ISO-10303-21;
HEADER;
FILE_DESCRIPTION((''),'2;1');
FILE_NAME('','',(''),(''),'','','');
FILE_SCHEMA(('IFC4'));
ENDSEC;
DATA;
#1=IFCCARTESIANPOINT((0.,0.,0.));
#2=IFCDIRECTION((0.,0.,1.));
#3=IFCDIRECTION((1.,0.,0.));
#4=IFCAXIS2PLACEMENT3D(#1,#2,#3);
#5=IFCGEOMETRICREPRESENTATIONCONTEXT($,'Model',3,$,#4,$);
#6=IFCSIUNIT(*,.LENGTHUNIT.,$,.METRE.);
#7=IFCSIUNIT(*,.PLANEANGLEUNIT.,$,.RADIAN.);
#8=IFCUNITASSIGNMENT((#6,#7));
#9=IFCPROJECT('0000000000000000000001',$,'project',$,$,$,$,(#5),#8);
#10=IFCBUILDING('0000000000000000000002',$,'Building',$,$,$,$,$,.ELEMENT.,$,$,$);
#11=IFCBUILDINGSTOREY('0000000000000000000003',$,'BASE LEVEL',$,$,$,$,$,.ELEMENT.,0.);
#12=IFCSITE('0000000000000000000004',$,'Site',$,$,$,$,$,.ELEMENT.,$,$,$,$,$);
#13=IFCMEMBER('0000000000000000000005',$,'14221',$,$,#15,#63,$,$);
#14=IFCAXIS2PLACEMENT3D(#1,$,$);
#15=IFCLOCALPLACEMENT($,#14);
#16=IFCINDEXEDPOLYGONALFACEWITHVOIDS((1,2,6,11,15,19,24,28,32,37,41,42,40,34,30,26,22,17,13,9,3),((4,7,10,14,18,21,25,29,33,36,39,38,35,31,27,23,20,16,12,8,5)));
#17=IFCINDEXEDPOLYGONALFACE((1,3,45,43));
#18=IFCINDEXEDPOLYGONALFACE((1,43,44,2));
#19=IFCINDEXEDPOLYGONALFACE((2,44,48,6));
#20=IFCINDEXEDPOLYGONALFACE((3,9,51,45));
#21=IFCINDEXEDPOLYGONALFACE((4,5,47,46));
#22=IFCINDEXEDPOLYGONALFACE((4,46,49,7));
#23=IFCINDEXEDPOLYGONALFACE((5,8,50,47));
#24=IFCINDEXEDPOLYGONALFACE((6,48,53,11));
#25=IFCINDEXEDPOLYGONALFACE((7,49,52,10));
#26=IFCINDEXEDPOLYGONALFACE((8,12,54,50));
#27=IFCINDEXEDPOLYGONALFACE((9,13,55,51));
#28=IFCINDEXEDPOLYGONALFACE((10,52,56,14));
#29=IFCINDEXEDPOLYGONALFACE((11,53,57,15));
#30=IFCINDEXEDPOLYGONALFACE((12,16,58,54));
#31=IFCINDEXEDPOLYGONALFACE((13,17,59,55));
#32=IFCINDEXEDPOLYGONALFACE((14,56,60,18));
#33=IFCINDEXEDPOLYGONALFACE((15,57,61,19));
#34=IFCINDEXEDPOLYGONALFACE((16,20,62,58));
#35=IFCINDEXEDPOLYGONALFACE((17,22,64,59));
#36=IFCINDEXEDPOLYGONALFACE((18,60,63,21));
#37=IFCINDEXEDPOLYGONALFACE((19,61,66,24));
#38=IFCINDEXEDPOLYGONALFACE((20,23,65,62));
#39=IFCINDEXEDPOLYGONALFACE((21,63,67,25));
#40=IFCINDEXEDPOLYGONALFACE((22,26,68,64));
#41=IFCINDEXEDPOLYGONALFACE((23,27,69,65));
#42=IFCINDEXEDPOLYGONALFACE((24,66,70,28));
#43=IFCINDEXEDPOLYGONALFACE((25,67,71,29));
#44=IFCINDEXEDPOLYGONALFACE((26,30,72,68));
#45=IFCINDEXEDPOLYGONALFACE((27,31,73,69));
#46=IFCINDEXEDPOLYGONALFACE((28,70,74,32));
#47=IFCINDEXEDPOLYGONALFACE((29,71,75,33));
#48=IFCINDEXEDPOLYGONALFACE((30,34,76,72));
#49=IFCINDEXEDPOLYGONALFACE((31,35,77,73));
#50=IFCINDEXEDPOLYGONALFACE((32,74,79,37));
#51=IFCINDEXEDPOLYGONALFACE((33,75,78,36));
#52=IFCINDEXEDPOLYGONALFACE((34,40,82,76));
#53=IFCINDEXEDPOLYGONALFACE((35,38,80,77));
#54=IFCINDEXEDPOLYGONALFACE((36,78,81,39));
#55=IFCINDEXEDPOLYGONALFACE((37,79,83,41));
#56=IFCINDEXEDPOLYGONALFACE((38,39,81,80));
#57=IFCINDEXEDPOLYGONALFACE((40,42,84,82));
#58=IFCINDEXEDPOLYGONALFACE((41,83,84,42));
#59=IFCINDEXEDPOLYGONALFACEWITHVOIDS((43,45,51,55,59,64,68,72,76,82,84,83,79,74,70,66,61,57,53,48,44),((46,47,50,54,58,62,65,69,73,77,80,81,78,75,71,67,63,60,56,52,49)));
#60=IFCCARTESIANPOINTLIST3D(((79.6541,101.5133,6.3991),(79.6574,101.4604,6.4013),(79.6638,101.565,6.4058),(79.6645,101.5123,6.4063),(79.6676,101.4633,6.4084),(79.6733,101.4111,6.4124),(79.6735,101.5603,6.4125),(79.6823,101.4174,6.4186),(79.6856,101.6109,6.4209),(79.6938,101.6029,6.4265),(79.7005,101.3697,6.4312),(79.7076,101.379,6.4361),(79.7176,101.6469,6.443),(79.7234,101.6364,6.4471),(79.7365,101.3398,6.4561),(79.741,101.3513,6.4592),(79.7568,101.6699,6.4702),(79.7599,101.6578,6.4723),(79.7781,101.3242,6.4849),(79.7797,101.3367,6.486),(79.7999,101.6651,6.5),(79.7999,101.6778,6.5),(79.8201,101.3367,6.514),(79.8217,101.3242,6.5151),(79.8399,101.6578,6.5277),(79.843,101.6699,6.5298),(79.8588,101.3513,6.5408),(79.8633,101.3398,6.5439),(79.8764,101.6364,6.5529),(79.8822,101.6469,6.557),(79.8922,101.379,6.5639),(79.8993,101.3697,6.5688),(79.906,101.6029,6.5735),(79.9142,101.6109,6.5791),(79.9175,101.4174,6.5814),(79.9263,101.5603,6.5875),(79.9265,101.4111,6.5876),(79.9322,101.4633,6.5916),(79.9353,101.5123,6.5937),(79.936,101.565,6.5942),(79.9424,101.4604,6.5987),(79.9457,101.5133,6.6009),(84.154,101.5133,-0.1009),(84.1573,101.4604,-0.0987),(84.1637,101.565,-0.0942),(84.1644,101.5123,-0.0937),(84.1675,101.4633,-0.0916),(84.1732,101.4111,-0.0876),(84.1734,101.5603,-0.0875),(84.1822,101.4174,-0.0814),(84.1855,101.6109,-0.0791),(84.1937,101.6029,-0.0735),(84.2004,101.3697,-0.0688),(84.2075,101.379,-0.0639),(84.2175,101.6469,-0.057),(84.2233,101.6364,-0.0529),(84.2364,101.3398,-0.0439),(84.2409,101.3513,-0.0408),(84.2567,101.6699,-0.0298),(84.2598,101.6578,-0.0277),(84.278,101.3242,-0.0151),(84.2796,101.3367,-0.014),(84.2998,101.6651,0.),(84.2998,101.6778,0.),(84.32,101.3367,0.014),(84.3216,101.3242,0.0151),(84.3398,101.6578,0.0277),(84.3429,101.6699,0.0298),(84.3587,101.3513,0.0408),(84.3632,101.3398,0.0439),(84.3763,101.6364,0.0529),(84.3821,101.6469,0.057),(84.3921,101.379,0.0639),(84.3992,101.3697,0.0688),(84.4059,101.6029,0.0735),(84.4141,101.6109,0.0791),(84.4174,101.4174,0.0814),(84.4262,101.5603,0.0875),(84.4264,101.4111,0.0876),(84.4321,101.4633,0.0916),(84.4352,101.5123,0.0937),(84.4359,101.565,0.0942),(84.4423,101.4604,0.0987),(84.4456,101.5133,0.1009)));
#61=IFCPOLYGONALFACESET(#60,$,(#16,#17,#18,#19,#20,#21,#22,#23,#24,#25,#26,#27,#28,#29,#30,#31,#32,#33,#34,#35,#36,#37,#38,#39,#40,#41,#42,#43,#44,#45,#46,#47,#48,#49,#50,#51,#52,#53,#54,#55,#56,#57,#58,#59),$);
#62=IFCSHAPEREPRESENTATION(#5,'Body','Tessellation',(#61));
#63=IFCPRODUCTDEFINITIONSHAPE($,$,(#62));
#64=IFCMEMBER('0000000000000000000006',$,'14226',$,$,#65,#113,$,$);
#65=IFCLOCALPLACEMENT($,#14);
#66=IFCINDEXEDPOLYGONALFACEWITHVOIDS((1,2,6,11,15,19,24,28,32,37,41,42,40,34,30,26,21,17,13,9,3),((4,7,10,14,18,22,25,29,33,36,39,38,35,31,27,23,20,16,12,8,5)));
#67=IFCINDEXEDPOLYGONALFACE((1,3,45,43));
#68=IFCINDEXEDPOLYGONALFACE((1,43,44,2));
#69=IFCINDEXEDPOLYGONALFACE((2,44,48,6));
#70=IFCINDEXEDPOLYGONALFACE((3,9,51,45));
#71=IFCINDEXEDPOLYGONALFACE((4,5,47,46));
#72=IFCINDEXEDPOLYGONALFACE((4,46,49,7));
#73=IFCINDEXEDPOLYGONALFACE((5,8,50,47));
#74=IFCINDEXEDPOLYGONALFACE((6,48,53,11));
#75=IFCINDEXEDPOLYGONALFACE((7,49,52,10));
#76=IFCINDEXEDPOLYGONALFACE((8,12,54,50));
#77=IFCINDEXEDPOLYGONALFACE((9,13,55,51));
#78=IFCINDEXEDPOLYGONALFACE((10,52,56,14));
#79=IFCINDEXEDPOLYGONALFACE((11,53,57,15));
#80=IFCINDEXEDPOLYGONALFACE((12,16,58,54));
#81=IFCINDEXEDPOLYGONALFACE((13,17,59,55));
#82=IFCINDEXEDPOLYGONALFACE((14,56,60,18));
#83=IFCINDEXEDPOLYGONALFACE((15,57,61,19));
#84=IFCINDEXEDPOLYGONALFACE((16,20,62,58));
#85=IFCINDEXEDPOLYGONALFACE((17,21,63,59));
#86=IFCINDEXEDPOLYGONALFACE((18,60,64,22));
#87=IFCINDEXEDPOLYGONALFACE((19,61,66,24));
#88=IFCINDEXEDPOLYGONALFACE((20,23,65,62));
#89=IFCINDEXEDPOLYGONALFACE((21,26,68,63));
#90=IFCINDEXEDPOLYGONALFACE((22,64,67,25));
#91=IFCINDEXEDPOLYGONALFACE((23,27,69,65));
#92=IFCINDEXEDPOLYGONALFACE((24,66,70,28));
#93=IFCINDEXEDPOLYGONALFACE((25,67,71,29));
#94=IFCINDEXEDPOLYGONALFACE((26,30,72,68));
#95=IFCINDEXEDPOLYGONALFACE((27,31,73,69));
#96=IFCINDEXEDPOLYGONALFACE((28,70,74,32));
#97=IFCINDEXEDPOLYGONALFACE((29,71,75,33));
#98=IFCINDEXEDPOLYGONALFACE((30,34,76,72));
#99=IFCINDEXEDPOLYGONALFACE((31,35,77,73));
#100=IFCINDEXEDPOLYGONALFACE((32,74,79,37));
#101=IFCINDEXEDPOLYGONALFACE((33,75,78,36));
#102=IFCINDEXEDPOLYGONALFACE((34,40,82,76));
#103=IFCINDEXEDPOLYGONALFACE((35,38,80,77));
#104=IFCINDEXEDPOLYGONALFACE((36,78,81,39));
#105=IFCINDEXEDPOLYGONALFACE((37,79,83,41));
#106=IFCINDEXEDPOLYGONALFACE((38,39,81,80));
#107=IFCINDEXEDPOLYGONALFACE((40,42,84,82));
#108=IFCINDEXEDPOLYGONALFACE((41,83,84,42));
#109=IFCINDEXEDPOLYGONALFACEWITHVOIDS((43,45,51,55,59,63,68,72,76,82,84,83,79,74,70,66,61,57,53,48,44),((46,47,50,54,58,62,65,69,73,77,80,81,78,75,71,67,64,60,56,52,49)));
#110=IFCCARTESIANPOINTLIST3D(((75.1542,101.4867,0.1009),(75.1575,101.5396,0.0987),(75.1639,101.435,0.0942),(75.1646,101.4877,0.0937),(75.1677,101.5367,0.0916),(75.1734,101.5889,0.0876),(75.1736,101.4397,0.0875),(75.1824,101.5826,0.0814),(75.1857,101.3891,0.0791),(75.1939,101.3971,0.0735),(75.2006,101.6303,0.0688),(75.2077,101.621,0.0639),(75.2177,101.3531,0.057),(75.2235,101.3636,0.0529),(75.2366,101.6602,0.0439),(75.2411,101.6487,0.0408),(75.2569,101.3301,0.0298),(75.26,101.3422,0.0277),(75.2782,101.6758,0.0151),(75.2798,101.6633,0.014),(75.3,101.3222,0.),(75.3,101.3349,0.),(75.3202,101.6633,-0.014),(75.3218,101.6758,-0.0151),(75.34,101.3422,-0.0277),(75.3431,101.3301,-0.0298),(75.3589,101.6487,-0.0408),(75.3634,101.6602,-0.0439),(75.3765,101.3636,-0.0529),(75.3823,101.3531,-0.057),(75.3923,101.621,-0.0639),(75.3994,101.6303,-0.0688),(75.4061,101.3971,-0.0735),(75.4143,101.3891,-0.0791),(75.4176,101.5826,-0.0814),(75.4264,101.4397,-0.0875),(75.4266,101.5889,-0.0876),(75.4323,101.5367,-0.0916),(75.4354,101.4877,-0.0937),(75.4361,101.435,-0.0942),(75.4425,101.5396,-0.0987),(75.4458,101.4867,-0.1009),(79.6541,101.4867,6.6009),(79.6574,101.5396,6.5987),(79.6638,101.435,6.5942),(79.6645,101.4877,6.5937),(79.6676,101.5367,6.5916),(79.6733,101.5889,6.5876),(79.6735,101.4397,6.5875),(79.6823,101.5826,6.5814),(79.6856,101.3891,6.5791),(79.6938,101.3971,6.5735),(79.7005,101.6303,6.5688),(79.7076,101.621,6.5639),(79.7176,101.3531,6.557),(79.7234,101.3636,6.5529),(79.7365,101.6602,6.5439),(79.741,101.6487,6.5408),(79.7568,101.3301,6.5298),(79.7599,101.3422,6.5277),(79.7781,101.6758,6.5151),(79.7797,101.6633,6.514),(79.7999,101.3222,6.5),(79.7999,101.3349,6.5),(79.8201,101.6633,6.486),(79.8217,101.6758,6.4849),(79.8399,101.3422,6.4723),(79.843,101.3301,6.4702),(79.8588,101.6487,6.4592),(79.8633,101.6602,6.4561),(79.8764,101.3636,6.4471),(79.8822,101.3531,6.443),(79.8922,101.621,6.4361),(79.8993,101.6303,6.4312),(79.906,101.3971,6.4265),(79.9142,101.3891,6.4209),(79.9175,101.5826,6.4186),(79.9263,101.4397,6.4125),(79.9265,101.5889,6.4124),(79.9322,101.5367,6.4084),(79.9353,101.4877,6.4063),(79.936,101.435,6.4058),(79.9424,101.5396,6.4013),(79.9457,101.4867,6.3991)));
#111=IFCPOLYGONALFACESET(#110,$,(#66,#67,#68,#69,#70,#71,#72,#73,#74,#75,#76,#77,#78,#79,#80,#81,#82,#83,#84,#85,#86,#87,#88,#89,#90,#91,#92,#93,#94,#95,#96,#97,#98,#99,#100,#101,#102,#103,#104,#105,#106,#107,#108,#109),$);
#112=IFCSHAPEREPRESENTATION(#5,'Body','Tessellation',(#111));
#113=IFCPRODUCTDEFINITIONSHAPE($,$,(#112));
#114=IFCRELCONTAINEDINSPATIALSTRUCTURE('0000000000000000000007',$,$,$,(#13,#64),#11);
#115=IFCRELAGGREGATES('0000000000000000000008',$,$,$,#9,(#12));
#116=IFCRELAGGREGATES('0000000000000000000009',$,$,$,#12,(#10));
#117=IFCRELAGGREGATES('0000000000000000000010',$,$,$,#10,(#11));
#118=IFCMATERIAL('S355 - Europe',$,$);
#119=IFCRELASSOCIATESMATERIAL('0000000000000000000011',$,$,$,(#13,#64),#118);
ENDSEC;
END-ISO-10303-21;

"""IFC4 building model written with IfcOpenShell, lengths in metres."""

from ifc_helpers import new_model, si_unit, frame, origin_with_axes, origin_2d_with_axis, place, context, project, spatial, hollow_circle, extrude, material, material_profile, profile_set, profile_usage, element, save


model = new_model("IFC4")

# Units and contexts
model_context = context("Model", 3, world=origin_with_axes())
ifc_project = project(units=[si_unit("LENGTHUNIT", "METRE"), si_unit("PLANEANGLEUNIT", "RADIAN")], contexts=[model_context])

# Site, building, storey
site = spatial("IfcSite", under=ifc_project, Name="Site", CompositionType="ELEMENT")
building = spatial("IfcBuilding", under=site, Name="Building", CompositionType="ELEMENT")
storey = spatial("IfcBuildingStorey", under=building, Name="BASE LEVEL", CompositionType="ELEMENT", Elevation=0.0)

# Shared definitions
ifc_material = material(Name="S355 - Europe")

# Members
ifc_material_profile_1 = material_profile(ifc_material, hollow_circle(Radius=0.1778, WallThickness=0.0127, at=origin_2d_with_axis()))
ifc_profile_set_1 = profile_set([ifc_material_profile_1])
ifc_profile_usage_1 = profile_usage(ifc_profile_set_1, cardinal=10)
member_1_placement = place(None, frame((79.7999, 101.5, 6.5), z_axis=(0.569201, 0.0, -0.822198), x_axis=(0.0, 1.0, 0.0)))
element("IfcMember", 1, at=member_1_placement, inside=storey, material=ifc_profile_usage_1, Name="14221", context=model_context, shape_type="SweptSolid", body=[
    extrude(hollow_circle(Radius=0.1778, WallThickness=0.0127, at=origin_2d_with_axis()), origin_with_axes(), (0.0, 0.0, 1.0), 7.9056),
])
ifc_material_profile_2 = material_profile(ifc_material, hollow_circle(Radius=0.1778, WallThickness=0.0127, at=origin_2d_with_axis()))
ifc_profile_set_2 = profile_set([ifc_material_profile_2])
ifc_profile_usage_2 = profile_usage(ifc_profile_set_2, cardinal=10)
member_2_placement = place(None, frame((79.7999, 101.5, 6.5), z_axis=(-0.569201, 0.0, -0.822198), x_axis=(0.0, -1.0, 0.0)))
element("IfcMember", 2, at=member_2_placement, inside=storey, material=ifc_profile_usage_2, Name="14226", context=model_context, shape_type="SweptSolid", body=[
    extrude(hollow_circle(Radius=0.1778, WallThickness=0.0127, at=origin_2d_with_axis()), origin_with_axes(), (0.0, 0.0, 1.0), 7.9056),
])

save(model, "model.ifc")
